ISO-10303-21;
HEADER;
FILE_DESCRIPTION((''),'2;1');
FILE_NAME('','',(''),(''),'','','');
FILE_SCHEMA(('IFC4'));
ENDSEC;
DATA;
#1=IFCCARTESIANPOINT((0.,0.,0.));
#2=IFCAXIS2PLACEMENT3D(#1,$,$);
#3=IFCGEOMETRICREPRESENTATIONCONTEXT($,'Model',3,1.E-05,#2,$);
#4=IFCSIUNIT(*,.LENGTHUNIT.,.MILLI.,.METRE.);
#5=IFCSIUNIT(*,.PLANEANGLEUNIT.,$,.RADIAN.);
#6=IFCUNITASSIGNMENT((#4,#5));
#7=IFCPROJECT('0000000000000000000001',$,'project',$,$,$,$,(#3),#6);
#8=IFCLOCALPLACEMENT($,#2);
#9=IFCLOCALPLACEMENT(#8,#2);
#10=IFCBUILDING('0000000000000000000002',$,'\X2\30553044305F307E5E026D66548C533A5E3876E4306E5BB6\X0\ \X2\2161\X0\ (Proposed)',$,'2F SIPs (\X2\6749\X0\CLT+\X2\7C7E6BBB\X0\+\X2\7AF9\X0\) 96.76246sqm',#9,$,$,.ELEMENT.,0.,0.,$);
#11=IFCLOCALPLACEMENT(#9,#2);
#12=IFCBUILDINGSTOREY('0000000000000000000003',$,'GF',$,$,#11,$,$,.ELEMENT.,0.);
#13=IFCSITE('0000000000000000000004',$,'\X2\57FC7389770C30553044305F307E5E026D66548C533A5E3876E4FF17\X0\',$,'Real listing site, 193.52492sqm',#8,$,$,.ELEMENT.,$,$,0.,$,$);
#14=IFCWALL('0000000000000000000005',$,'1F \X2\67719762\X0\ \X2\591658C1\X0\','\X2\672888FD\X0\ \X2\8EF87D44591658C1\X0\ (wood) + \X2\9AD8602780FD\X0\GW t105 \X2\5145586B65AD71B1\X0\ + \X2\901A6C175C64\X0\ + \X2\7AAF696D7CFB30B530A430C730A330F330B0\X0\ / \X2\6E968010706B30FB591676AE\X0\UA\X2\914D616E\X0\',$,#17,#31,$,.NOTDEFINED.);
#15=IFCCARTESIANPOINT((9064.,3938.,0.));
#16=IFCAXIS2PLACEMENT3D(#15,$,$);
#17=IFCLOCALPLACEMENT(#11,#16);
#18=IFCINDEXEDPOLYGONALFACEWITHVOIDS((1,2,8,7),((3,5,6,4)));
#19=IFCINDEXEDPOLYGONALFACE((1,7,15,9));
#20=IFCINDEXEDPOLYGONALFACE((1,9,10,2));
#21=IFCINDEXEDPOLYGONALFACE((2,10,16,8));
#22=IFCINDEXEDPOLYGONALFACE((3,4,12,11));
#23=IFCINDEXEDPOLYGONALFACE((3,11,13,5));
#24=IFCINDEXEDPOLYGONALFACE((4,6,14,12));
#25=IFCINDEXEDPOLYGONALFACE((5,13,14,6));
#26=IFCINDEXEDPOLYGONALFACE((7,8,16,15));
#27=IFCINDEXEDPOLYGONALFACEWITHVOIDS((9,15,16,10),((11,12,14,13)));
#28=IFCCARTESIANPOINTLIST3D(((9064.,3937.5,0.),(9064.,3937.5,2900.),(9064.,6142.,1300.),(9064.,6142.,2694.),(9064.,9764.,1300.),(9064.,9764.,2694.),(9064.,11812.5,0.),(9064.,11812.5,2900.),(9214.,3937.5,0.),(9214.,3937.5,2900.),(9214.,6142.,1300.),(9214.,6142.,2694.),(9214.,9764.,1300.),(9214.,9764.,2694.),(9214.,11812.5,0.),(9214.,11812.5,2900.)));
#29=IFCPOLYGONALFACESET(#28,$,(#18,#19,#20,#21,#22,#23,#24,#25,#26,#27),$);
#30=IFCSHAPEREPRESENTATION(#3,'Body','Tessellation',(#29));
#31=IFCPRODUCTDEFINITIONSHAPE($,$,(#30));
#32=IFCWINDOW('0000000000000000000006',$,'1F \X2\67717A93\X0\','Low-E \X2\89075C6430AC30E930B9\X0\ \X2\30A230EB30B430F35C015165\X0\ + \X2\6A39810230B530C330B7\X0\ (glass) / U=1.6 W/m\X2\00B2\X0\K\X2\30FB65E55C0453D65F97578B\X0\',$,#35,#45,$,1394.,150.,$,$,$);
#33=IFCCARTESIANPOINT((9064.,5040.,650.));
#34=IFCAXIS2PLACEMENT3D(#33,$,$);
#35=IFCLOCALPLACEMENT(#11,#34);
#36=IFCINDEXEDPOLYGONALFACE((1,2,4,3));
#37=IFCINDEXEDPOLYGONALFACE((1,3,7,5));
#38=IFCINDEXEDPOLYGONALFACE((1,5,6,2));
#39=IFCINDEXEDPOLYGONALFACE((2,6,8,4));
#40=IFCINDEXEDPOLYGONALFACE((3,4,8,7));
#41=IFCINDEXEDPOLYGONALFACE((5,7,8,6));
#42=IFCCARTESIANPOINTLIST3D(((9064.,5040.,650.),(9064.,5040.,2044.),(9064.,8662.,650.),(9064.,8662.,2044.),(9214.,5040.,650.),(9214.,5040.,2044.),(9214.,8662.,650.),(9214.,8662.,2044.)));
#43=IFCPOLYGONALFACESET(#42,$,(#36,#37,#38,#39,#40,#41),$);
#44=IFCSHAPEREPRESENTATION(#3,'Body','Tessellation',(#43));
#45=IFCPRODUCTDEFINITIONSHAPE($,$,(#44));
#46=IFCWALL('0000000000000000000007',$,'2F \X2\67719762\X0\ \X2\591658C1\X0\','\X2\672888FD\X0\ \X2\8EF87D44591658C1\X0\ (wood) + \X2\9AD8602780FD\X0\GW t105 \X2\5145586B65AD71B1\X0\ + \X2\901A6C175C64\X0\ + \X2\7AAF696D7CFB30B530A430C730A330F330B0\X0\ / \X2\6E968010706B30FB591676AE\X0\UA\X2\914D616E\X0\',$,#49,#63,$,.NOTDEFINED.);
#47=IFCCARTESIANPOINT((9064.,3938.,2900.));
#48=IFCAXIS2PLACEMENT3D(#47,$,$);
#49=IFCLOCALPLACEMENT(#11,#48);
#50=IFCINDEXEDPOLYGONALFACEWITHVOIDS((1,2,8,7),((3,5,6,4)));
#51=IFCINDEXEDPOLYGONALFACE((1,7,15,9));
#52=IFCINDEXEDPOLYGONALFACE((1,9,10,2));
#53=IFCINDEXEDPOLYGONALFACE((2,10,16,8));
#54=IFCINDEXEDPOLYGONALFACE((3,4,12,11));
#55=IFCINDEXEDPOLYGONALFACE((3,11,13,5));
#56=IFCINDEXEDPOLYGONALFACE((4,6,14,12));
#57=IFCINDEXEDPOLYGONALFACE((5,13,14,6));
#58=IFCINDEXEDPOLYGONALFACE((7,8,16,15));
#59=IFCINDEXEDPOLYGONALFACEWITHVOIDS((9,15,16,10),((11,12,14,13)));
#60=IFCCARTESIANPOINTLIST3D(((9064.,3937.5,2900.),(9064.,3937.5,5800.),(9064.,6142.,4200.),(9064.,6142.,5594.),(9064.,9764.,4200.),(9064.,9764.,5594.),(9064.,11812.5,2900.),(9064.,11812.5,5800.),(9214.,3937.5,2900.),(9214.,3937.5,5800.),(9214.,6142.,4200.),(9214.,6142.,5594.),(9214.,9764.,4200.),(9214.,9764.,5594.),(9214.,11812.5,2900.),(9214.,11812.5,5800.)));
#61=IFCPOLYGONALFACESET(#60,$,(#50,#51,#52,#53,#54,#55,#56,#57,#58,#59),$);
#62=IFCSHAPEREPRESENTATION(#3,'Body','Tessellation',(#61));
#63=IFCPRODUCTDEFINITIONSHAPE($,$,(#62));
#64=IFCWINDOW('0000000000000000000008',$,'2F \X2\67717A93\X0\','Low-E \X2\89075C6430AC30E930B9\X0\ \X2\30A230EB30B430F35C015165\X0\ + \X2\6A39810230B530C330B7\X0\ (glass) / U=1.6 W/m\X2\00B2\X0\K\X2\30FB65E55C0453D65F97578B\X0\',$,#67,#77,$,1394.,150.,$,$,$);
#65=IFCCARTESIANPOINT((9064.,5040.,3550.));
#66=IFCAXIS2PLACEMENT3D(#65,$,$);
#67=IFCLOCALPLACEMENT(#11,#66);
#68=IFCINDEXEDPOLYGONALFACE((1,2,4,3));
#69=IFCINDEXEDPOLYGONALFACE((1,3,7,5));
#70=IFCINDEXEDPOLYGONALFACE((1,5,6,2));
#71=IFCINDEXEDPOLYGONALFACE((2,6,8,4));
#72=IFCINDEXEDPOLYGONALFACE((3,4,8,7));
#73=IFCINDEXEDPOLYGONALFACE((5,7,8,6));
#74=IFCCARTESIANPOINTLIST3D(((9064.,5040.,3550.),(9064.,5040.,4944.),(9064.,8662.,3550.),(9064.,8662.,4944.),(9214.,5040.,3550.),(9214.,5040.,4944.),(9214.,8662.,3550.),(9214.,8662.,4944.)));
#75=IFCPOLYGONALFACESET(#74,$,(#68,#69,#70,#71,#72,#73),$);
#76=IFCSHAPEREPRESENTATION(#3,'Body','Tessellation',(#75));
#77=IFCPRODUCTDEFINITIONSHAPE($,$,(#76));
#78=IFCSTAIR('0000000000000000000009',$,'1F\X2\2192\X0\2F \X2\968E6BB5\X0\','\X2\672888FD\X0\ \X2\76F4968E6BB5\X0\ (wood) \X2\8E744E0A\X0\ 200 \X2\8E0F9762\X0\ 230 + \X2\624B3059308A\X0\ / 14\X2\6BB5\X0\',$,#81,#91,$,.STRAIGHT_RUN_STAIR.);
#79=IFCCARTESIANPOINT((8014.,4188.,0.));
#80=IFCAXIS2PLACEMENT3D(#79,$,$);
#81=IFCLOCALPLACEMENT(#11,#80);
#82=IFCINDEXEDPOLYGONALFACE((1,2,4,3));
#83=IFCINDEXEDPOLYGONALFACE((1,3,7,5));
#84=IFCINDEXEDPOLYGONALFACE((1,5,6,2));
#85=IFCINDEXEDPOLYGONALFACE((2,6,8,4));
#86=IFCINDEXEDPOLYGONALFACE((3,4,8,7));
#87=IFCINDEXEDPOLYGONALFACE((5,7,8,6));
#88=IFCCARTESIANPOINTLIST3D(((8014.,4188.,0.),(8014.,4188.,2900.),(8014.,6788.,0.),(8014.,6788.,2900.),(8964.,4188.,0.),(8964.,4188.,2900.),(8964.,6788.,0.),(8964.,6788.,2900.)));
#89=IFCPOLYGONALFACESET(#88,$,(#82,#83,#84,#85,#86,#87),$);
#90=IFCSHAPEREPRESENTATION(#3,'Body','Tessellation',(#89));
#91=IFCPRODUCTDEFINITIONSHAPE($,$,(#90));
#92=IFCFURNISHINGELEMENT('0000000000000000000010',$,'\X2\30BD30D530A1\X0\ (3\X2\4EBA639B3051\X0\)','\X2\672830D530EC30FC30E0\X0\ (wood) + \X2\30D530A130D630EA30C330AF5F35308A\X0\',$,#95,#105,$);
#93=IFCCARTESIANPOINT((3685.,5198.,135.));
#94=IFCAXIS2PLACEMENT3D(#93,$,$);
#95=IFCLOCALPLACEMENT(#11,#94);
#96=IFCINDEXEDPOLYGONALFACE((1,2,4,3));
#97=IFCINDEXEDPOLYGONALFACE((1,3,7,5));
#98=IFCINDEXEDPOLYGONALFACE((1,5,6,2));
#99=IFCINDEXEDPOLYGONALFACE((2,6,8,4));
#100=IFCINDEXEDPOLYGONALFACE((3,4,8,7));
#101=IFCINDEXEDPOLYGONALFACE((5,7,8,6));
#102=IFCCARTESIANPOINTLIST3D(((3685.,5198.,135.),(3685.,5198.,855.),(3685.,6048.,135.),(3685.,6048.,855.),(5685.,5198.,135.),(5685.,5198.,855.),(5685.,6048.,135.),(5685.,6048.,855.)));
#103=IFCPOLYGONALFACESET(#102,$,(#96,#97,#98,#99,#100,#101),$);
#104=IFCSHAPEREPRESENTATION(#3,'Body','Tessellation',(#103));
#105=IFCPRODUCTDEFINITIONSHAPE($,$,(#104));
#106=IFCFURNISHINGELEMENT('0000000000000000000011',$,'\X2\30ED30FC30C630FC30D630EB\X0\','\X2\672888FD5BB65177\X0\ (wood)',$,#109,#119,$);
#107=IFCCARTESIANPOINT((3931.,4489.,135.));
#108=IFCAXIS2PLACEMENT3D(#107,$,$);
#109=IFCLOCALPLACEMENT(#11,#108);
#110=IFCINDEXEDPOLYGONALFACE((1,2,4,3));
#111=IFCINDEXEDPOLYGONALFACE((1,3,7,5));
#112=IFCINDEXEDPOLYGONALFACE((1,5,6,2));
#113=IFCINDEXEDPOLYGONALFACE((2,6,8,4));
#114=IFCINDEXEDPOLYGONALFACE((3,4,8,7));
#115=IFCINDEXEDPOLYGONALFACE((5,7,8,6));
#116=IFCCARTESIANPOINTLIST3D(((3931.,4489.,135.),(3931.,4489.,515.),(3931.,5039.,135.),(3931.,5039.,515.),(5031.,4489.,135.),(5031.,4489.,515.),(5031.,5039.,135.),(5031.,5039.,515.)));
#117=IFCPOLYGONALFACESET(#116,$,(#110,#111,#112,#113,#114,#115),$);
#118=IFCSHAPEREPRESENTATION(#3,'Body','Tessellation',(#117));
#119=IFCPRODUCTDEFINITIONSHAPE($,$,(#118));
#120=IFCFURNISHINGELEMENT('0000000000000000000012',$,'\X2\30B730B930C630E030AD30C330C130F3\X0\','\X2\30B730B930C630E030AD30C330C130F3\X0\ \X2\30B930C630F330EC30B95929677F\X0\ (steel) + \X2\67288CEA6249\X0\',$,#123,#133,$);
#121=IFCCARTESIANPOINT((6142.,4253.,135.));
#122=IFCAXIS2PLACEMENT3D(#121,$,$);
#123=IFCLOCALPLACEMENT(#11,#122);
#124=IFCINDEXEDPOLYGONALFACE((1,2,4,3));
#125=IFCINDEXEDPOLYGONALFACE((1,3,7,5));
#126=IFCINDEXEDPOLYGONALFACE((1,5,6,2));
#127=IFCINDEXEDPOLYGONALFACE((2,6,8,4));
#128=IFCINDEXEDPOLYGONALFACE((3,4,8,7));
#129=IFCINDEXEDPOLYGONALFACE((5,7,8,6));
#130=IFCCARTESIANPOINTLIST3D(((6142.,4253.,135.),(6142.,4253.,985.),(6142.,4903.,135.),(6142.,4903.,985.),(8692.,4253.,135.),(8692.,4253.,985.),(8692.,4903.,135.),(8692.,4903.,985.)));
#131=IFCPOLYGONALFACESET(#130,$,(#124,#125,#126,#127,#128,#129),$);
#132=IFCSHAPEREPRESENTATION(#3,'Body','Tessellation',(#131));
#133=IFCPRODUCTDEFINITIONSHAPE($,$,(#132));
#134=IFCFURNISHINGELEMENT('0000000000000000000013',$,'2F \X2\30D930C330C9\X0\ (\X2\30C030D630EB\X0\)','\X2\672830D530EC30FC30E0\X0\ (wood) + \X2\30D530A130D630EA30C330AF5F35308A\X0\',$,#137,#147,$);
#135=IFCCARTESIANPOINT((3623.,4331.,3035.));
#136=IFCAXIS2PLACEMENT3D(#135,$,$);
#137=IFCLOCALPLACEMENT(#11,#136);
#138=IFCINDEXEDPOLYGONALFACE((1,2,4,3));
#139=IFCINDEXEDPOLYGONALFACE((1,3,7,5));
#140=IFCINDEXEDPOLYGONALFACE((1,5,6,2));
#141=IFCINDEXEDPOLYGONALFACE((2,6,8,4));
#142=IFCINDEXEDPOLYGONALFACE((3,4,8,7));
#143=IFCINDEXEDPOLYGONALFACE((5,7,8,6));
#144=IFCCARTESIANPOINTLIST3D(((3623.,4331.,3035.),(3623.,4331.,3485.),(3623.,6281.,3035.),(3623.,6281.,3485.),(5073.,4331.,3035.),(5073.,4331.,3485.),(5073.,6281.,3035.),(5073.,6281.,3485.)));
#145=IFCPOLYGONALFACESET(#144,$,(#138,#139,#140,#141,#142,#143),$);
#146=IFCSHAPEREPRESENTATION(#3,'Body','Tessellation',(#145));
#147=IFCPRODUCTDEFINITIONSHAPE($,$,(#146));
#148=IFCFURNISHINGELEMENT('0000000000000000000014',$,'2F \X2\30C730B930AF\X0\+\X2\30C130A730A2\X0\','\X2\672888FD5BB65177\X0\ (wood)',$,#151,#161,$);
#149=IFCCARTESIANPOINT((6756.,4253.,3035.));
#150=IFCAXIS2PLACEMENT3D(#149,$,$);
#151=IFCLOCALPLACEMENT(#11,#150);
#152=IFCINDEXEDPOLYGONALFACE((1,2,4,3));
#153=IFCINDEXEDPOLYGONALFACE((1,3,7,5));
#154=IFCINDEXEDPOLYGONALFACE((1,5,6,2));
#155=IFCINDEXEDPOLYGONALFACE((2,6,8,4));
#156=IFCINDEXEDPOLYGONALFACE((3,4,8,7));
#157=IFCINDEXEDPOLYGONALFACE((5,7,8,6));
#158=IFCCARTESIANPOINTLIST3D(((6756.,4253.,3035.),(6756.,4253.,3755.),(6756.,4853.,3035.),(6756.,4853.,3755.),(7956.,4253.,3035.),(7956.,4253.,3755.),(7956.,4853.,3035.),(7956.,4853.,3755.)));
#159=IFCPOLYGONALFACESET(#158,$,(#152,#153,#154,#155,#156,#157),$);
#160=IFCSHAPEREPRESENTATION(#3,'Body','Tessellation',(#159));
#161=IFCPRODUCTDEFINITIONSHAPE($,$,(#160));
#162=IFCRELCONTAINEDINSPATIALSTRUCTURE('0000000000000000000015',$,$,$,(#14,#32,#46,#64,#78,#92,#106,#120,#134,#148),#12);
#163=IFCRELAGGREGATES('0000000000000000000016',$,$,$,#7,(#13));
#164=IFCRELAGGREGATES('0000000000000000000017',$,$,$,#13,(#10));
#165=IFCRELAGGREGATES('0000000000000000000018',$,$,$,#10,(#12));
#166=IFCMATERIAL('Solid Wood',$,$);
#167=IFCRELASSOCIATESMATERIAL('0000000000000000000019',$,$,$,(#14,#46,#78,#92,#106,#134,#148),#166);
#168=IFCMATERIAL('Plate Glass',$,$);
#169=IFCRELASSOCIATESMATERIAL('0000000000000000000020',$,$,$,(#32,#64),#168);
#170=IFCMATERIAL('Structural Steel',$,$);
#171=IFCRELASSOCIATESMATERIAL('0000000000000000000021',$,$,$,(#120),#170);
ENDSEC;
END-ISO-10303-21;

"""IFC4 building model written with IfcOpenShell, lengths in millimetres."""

from ifc_helpers import new_model, si_unit, frame, frame_2d, origin, place, context, project, spatial, rectangle, extrude, material, element, fill, save


model = new_model("IFC4")

# Units and contexts
model_context = context("Model", 3, precision=1e-05, world=origin())
ifc_project = project(units=[si_unit("LENGTHUNIT", "METRE", prefix="MILLI"), si_unit("PLANEANGLEUNIT", "RADIAN")], contexts=[model_context])

# Site, building, storey
site_placement = place(None, origin())
site = spatial("IfcSite", under=ifc_project, at=site_placement, Name="埼玉県さいたま市浦和区常盤７", ObjectType="Real listing site, 193.52492sqm", CompositionType="ELEMENT", RefElevation=0.0)
building_placement = place(site_placement, origin())
building = spatial("IfcBuilding", under=site, at=building_placement, Name="さいたま市浦和区常盤の家 Ⅱ (Proposed)", ObjectType="2F SIPs (杉CLT+籾殻+竹) 96.76246sqm", CompositionType="ELEMENT", ElevationOfRefHeight=0.0, ElevationOfTerrain=0.0)
storey_placement = place(building_placement, origin())
storey = spatial("IfcBuildingStorey", under=building, at=storey_placement, Name="GF", CompositionType="ELEMENT", Elevation=0.0)

# Wall, opening, window
ifc_material_1 = material(Name="Solid Wood")
wall_1_placement = place(storey_placement, frame((9064.0, 3938.0, 0.0)))
wall_1 = element("IfcWall", 1, at=wall_1_placement, inside=storey, material=ifc_material_1, Name="1F 東面 外壁", Description="木製 軸組外壁 (wood) + 高性能GW t105 充填断熱 + 通気層 + 窯業系サイディング / 準耐火・外皮UA配慮", PredefinedType="NOTDEFINED", context=model_context, shape_type="SweptSolid", body=[
    extrude(rectangle(XDim=150.0, YDim=7875.0, at=frame_2d((75.0, 3937.0))), frame((9064.0, 3938.0, 0.0)), (0.0, 0.0, 1.0), 2900.0),
])
opening_1_placement = place(storey_placement, frame((9064.0, 5040.0, 650.0)))
opening_1 = element("IfcOpeningElement", 2, at=opening_1_placement, cuts=wall_1, PredefinedType="NOTDEFINED", context=model_context, shape_type="SweptSolid", body=[
    extrude(rectangle(XDim=150.0, YDim=3622.0, at=frame_2d((75.0, 1811.0))), frame((9064.0, 5040.0, 650.0)), (0.0, 0.0, 1.0), 1394.0),
])
ifc_material_2 = material(Name="Plate Glass")
window_1_placement = place(storey_placement, frame((9064.0, 5040.0, 650.0)))
window_1 = element("IfcWindow", 3, at=window_1_placement, inside=storey, material=ifc_material_2, Name="1F 東窓", Description="Low-E 複層ガラス アルゴン封入 + 樹脂サッシ (glass) / U=1.6 W/m²K・日射取得型", OverallHeight=1394.0, OverallWidth=150.0, context=model_context, shape_type="SweptSolid", body=[
    extrude(rectangle(XDim=150.0, YDim=3622.0, at=frame_2d((75.0, 1811.0))), frame((9064.0, 5040.0, 650.0)), (0.0, 0.0, 1.0), 1394.0),
])
fill(opening_1, window_1)

# Wall, opening, window
wall_2_placement = place(storey_placement, frame((9064.0, 3938.0, 2900.0)))
wall_2 = element("IfcWall", 4, at=wall_2_placement, inside=storey, material=ifc_material_1, Name="2F 東面 外壁", Description="木製 軸組外壁 (wood) + 高性能GW t105 充填断熱 + 通気層 + 窯業系サイディング / 準耐火・外皮UA配慮", PredefinedType="NOTDEFINED", context=model_context, shape_type="SweptSolid", body=[
    extrude(rectangle(XDim=150.0, YDim=7875.0, at=frame_2d((75.0, 3937.0))), frame((9064.0, 3938.0, 2900.0)), (0.0, 0.0, 1.0), 2900.0),
])
opening_2_placement = place(storey_placement, frame((9064.0, 5040.0, 3550.0)))
opening_2 = element("IfcOpeningElement", 5, at=opening_2_placement, cuts=wall_2, PredefinedType="NOTDEFINED", context=model_context, shape_type="SweptSolid", body=[
    extrude(rectangle(XDim=150.0, YDim=3622.0, at=frame_2d((75.0, 1811.0))), frame((9064.0, 5040.0, 3550.0)), (0.0, 0.0, 1.0), 1394.0),
])
window_2_placement = place(storey_placement, frame((9064.0, 5040.0, 3550.0)))
window_2 = element("IfcWindow", 6, at=window_2_placement, inside=storey, material=ifc_material_2, Name="2F 東窓", Description="Low-E 複層ガラス アルゴン封入 + 樹脂サッシ (glass) / U=1.6 W/m²K・日射取得型", OverallHeight=1394.0, OverallWidth=150.0, context=model_context, shape_type="SweptSolid", body=[
    extrude(rectangle(XDim=150.0, YDim=3622.0, at=frame_2d((75.0, 1811.0))), frame((9064.0, 5040.0, 3550.0)), (0.0, 0.0, 1.0), 1394.0),
])
fill(opening_2, window_2)

# Stair
stair_placement = place(storey_placement, frame((8014.0, 4188.0, 0.0)))
element("IfcStair", 7, at=stair_placement, inside=storey, material=ifc_material_1, Name="1F→2F 階段", Description="木製 直階段 (wood) 蹴上 200 踏面 230 + 手すり / 14段", PredefinedType="STRAIGHT_RUN_STAIR", context=model_context, shape_type="SweptSolid", body=[
    extrude(rectangle(XDim=950.0, YDim=2600.0, at=frame_2d((475.0, 1300.0))), frame((8014.0, 4188.0, 0.0)), (0.0, 0.0, 1.0), 2900.0),
])

# Furnishing elements
furnishing_1_placement = place(storey_placement, frame((3685.0, 5198.0, 135.0)))
element("IfcFurnishingElement", 8, at=furnishing_1_placement, inside=storey, material=ifc_material_1, Name="ソファ (3人掛け)", Description="木フレーム (wood) + ファブリック張り", context=model_context, shape_type="SweptSolid", body=[
    extrude(rectangle(XDim=2000.0, YDim=850.0, at=frame_2d((1000.0, 425.0))), frame((3685.0, 5198.0, 135.0)), (0.0, 0.0, 1.0), 720.0),
])
furnishing_2_placement = place(storey_placement, frame((3931.0, 4489.0, 135.0)))
element("IfcFurnishingElement", 9, at=furnishing_2_placement, inside=storey, material=ifc_material_1, Name="ローテーブル", Description="木製家具 (wood)", context=model_context, shape_type="SweptSolid", body=[
    extrude(rectangle(XDim=1100.0, YDim=550.0, at=frame_2d((550.0, 275.0))), frame((3931.0, 4489.0, 135.0)), (0.0, 0.0, 1.0), 380.0),
])
ifc_material_3 = material(Name="Structural Steel")
furnishing_3_placement = place(storey_placement, frame((6142.0, 4253.0, 135.0)))
element("IfcFurnishingElement", 10, at=furnishing_3_placement, inside=storey, material=ifc_material_3, Name="システムキッチン", Description="システムキッチン ステンレス天板 (steel) + 木質扉", context=model_context, shape_type="SweptSolid", body=[
    extrude(rectangle(XDim=2550.0, YDim=650.0, at=frame_2d((1275.0, 325.0))), frame((6142.0, 4253.0, 135.0)), (0.0, 0.0, 1.0), 850.0),
])
furnishing_4_placement = place(storey_placement, frame((3623.0, 4331.0, 3035.0)))
element("IfcFurnishingElement", 11, at=furnishing_4_placement, inside=storey, material=ifc_material_1, Name="2F ベッド (ダブル)", Description="木フレーム (wood) + ファブリック張り", context=model_context, shape_type="SweptSolid", body=[
    extrude(rectangle(XDim=1450.0, YDim=1950.0, at=frame_2d((725.0, 975.0))), frame((3623.0, 4331.0, 3035.0)), (0.0, 0.0, 1.0), 450.0),
])
furnishing_5_placement = place(storey_placement, frame((6756.0, 4253.0, 3035.0)))
element("IfcFurnishingElement", 12, at=furnishing_5_placement, inside=storey, material=ifc_material_1, Name="2F デスク+チェア", Description="木製家具 (wood)", context=model_context, shape_type="SweptSolid", body=[
    extrude(rectangle(XDim=1200.0, YDim=600.0, at=frame_2d((600.0, 300.0))), frame((6756.0, 4253.0, 3035.0)), (0.0, 0.0, 1.0), 720.0),
])

save(model, "model.ifc")
